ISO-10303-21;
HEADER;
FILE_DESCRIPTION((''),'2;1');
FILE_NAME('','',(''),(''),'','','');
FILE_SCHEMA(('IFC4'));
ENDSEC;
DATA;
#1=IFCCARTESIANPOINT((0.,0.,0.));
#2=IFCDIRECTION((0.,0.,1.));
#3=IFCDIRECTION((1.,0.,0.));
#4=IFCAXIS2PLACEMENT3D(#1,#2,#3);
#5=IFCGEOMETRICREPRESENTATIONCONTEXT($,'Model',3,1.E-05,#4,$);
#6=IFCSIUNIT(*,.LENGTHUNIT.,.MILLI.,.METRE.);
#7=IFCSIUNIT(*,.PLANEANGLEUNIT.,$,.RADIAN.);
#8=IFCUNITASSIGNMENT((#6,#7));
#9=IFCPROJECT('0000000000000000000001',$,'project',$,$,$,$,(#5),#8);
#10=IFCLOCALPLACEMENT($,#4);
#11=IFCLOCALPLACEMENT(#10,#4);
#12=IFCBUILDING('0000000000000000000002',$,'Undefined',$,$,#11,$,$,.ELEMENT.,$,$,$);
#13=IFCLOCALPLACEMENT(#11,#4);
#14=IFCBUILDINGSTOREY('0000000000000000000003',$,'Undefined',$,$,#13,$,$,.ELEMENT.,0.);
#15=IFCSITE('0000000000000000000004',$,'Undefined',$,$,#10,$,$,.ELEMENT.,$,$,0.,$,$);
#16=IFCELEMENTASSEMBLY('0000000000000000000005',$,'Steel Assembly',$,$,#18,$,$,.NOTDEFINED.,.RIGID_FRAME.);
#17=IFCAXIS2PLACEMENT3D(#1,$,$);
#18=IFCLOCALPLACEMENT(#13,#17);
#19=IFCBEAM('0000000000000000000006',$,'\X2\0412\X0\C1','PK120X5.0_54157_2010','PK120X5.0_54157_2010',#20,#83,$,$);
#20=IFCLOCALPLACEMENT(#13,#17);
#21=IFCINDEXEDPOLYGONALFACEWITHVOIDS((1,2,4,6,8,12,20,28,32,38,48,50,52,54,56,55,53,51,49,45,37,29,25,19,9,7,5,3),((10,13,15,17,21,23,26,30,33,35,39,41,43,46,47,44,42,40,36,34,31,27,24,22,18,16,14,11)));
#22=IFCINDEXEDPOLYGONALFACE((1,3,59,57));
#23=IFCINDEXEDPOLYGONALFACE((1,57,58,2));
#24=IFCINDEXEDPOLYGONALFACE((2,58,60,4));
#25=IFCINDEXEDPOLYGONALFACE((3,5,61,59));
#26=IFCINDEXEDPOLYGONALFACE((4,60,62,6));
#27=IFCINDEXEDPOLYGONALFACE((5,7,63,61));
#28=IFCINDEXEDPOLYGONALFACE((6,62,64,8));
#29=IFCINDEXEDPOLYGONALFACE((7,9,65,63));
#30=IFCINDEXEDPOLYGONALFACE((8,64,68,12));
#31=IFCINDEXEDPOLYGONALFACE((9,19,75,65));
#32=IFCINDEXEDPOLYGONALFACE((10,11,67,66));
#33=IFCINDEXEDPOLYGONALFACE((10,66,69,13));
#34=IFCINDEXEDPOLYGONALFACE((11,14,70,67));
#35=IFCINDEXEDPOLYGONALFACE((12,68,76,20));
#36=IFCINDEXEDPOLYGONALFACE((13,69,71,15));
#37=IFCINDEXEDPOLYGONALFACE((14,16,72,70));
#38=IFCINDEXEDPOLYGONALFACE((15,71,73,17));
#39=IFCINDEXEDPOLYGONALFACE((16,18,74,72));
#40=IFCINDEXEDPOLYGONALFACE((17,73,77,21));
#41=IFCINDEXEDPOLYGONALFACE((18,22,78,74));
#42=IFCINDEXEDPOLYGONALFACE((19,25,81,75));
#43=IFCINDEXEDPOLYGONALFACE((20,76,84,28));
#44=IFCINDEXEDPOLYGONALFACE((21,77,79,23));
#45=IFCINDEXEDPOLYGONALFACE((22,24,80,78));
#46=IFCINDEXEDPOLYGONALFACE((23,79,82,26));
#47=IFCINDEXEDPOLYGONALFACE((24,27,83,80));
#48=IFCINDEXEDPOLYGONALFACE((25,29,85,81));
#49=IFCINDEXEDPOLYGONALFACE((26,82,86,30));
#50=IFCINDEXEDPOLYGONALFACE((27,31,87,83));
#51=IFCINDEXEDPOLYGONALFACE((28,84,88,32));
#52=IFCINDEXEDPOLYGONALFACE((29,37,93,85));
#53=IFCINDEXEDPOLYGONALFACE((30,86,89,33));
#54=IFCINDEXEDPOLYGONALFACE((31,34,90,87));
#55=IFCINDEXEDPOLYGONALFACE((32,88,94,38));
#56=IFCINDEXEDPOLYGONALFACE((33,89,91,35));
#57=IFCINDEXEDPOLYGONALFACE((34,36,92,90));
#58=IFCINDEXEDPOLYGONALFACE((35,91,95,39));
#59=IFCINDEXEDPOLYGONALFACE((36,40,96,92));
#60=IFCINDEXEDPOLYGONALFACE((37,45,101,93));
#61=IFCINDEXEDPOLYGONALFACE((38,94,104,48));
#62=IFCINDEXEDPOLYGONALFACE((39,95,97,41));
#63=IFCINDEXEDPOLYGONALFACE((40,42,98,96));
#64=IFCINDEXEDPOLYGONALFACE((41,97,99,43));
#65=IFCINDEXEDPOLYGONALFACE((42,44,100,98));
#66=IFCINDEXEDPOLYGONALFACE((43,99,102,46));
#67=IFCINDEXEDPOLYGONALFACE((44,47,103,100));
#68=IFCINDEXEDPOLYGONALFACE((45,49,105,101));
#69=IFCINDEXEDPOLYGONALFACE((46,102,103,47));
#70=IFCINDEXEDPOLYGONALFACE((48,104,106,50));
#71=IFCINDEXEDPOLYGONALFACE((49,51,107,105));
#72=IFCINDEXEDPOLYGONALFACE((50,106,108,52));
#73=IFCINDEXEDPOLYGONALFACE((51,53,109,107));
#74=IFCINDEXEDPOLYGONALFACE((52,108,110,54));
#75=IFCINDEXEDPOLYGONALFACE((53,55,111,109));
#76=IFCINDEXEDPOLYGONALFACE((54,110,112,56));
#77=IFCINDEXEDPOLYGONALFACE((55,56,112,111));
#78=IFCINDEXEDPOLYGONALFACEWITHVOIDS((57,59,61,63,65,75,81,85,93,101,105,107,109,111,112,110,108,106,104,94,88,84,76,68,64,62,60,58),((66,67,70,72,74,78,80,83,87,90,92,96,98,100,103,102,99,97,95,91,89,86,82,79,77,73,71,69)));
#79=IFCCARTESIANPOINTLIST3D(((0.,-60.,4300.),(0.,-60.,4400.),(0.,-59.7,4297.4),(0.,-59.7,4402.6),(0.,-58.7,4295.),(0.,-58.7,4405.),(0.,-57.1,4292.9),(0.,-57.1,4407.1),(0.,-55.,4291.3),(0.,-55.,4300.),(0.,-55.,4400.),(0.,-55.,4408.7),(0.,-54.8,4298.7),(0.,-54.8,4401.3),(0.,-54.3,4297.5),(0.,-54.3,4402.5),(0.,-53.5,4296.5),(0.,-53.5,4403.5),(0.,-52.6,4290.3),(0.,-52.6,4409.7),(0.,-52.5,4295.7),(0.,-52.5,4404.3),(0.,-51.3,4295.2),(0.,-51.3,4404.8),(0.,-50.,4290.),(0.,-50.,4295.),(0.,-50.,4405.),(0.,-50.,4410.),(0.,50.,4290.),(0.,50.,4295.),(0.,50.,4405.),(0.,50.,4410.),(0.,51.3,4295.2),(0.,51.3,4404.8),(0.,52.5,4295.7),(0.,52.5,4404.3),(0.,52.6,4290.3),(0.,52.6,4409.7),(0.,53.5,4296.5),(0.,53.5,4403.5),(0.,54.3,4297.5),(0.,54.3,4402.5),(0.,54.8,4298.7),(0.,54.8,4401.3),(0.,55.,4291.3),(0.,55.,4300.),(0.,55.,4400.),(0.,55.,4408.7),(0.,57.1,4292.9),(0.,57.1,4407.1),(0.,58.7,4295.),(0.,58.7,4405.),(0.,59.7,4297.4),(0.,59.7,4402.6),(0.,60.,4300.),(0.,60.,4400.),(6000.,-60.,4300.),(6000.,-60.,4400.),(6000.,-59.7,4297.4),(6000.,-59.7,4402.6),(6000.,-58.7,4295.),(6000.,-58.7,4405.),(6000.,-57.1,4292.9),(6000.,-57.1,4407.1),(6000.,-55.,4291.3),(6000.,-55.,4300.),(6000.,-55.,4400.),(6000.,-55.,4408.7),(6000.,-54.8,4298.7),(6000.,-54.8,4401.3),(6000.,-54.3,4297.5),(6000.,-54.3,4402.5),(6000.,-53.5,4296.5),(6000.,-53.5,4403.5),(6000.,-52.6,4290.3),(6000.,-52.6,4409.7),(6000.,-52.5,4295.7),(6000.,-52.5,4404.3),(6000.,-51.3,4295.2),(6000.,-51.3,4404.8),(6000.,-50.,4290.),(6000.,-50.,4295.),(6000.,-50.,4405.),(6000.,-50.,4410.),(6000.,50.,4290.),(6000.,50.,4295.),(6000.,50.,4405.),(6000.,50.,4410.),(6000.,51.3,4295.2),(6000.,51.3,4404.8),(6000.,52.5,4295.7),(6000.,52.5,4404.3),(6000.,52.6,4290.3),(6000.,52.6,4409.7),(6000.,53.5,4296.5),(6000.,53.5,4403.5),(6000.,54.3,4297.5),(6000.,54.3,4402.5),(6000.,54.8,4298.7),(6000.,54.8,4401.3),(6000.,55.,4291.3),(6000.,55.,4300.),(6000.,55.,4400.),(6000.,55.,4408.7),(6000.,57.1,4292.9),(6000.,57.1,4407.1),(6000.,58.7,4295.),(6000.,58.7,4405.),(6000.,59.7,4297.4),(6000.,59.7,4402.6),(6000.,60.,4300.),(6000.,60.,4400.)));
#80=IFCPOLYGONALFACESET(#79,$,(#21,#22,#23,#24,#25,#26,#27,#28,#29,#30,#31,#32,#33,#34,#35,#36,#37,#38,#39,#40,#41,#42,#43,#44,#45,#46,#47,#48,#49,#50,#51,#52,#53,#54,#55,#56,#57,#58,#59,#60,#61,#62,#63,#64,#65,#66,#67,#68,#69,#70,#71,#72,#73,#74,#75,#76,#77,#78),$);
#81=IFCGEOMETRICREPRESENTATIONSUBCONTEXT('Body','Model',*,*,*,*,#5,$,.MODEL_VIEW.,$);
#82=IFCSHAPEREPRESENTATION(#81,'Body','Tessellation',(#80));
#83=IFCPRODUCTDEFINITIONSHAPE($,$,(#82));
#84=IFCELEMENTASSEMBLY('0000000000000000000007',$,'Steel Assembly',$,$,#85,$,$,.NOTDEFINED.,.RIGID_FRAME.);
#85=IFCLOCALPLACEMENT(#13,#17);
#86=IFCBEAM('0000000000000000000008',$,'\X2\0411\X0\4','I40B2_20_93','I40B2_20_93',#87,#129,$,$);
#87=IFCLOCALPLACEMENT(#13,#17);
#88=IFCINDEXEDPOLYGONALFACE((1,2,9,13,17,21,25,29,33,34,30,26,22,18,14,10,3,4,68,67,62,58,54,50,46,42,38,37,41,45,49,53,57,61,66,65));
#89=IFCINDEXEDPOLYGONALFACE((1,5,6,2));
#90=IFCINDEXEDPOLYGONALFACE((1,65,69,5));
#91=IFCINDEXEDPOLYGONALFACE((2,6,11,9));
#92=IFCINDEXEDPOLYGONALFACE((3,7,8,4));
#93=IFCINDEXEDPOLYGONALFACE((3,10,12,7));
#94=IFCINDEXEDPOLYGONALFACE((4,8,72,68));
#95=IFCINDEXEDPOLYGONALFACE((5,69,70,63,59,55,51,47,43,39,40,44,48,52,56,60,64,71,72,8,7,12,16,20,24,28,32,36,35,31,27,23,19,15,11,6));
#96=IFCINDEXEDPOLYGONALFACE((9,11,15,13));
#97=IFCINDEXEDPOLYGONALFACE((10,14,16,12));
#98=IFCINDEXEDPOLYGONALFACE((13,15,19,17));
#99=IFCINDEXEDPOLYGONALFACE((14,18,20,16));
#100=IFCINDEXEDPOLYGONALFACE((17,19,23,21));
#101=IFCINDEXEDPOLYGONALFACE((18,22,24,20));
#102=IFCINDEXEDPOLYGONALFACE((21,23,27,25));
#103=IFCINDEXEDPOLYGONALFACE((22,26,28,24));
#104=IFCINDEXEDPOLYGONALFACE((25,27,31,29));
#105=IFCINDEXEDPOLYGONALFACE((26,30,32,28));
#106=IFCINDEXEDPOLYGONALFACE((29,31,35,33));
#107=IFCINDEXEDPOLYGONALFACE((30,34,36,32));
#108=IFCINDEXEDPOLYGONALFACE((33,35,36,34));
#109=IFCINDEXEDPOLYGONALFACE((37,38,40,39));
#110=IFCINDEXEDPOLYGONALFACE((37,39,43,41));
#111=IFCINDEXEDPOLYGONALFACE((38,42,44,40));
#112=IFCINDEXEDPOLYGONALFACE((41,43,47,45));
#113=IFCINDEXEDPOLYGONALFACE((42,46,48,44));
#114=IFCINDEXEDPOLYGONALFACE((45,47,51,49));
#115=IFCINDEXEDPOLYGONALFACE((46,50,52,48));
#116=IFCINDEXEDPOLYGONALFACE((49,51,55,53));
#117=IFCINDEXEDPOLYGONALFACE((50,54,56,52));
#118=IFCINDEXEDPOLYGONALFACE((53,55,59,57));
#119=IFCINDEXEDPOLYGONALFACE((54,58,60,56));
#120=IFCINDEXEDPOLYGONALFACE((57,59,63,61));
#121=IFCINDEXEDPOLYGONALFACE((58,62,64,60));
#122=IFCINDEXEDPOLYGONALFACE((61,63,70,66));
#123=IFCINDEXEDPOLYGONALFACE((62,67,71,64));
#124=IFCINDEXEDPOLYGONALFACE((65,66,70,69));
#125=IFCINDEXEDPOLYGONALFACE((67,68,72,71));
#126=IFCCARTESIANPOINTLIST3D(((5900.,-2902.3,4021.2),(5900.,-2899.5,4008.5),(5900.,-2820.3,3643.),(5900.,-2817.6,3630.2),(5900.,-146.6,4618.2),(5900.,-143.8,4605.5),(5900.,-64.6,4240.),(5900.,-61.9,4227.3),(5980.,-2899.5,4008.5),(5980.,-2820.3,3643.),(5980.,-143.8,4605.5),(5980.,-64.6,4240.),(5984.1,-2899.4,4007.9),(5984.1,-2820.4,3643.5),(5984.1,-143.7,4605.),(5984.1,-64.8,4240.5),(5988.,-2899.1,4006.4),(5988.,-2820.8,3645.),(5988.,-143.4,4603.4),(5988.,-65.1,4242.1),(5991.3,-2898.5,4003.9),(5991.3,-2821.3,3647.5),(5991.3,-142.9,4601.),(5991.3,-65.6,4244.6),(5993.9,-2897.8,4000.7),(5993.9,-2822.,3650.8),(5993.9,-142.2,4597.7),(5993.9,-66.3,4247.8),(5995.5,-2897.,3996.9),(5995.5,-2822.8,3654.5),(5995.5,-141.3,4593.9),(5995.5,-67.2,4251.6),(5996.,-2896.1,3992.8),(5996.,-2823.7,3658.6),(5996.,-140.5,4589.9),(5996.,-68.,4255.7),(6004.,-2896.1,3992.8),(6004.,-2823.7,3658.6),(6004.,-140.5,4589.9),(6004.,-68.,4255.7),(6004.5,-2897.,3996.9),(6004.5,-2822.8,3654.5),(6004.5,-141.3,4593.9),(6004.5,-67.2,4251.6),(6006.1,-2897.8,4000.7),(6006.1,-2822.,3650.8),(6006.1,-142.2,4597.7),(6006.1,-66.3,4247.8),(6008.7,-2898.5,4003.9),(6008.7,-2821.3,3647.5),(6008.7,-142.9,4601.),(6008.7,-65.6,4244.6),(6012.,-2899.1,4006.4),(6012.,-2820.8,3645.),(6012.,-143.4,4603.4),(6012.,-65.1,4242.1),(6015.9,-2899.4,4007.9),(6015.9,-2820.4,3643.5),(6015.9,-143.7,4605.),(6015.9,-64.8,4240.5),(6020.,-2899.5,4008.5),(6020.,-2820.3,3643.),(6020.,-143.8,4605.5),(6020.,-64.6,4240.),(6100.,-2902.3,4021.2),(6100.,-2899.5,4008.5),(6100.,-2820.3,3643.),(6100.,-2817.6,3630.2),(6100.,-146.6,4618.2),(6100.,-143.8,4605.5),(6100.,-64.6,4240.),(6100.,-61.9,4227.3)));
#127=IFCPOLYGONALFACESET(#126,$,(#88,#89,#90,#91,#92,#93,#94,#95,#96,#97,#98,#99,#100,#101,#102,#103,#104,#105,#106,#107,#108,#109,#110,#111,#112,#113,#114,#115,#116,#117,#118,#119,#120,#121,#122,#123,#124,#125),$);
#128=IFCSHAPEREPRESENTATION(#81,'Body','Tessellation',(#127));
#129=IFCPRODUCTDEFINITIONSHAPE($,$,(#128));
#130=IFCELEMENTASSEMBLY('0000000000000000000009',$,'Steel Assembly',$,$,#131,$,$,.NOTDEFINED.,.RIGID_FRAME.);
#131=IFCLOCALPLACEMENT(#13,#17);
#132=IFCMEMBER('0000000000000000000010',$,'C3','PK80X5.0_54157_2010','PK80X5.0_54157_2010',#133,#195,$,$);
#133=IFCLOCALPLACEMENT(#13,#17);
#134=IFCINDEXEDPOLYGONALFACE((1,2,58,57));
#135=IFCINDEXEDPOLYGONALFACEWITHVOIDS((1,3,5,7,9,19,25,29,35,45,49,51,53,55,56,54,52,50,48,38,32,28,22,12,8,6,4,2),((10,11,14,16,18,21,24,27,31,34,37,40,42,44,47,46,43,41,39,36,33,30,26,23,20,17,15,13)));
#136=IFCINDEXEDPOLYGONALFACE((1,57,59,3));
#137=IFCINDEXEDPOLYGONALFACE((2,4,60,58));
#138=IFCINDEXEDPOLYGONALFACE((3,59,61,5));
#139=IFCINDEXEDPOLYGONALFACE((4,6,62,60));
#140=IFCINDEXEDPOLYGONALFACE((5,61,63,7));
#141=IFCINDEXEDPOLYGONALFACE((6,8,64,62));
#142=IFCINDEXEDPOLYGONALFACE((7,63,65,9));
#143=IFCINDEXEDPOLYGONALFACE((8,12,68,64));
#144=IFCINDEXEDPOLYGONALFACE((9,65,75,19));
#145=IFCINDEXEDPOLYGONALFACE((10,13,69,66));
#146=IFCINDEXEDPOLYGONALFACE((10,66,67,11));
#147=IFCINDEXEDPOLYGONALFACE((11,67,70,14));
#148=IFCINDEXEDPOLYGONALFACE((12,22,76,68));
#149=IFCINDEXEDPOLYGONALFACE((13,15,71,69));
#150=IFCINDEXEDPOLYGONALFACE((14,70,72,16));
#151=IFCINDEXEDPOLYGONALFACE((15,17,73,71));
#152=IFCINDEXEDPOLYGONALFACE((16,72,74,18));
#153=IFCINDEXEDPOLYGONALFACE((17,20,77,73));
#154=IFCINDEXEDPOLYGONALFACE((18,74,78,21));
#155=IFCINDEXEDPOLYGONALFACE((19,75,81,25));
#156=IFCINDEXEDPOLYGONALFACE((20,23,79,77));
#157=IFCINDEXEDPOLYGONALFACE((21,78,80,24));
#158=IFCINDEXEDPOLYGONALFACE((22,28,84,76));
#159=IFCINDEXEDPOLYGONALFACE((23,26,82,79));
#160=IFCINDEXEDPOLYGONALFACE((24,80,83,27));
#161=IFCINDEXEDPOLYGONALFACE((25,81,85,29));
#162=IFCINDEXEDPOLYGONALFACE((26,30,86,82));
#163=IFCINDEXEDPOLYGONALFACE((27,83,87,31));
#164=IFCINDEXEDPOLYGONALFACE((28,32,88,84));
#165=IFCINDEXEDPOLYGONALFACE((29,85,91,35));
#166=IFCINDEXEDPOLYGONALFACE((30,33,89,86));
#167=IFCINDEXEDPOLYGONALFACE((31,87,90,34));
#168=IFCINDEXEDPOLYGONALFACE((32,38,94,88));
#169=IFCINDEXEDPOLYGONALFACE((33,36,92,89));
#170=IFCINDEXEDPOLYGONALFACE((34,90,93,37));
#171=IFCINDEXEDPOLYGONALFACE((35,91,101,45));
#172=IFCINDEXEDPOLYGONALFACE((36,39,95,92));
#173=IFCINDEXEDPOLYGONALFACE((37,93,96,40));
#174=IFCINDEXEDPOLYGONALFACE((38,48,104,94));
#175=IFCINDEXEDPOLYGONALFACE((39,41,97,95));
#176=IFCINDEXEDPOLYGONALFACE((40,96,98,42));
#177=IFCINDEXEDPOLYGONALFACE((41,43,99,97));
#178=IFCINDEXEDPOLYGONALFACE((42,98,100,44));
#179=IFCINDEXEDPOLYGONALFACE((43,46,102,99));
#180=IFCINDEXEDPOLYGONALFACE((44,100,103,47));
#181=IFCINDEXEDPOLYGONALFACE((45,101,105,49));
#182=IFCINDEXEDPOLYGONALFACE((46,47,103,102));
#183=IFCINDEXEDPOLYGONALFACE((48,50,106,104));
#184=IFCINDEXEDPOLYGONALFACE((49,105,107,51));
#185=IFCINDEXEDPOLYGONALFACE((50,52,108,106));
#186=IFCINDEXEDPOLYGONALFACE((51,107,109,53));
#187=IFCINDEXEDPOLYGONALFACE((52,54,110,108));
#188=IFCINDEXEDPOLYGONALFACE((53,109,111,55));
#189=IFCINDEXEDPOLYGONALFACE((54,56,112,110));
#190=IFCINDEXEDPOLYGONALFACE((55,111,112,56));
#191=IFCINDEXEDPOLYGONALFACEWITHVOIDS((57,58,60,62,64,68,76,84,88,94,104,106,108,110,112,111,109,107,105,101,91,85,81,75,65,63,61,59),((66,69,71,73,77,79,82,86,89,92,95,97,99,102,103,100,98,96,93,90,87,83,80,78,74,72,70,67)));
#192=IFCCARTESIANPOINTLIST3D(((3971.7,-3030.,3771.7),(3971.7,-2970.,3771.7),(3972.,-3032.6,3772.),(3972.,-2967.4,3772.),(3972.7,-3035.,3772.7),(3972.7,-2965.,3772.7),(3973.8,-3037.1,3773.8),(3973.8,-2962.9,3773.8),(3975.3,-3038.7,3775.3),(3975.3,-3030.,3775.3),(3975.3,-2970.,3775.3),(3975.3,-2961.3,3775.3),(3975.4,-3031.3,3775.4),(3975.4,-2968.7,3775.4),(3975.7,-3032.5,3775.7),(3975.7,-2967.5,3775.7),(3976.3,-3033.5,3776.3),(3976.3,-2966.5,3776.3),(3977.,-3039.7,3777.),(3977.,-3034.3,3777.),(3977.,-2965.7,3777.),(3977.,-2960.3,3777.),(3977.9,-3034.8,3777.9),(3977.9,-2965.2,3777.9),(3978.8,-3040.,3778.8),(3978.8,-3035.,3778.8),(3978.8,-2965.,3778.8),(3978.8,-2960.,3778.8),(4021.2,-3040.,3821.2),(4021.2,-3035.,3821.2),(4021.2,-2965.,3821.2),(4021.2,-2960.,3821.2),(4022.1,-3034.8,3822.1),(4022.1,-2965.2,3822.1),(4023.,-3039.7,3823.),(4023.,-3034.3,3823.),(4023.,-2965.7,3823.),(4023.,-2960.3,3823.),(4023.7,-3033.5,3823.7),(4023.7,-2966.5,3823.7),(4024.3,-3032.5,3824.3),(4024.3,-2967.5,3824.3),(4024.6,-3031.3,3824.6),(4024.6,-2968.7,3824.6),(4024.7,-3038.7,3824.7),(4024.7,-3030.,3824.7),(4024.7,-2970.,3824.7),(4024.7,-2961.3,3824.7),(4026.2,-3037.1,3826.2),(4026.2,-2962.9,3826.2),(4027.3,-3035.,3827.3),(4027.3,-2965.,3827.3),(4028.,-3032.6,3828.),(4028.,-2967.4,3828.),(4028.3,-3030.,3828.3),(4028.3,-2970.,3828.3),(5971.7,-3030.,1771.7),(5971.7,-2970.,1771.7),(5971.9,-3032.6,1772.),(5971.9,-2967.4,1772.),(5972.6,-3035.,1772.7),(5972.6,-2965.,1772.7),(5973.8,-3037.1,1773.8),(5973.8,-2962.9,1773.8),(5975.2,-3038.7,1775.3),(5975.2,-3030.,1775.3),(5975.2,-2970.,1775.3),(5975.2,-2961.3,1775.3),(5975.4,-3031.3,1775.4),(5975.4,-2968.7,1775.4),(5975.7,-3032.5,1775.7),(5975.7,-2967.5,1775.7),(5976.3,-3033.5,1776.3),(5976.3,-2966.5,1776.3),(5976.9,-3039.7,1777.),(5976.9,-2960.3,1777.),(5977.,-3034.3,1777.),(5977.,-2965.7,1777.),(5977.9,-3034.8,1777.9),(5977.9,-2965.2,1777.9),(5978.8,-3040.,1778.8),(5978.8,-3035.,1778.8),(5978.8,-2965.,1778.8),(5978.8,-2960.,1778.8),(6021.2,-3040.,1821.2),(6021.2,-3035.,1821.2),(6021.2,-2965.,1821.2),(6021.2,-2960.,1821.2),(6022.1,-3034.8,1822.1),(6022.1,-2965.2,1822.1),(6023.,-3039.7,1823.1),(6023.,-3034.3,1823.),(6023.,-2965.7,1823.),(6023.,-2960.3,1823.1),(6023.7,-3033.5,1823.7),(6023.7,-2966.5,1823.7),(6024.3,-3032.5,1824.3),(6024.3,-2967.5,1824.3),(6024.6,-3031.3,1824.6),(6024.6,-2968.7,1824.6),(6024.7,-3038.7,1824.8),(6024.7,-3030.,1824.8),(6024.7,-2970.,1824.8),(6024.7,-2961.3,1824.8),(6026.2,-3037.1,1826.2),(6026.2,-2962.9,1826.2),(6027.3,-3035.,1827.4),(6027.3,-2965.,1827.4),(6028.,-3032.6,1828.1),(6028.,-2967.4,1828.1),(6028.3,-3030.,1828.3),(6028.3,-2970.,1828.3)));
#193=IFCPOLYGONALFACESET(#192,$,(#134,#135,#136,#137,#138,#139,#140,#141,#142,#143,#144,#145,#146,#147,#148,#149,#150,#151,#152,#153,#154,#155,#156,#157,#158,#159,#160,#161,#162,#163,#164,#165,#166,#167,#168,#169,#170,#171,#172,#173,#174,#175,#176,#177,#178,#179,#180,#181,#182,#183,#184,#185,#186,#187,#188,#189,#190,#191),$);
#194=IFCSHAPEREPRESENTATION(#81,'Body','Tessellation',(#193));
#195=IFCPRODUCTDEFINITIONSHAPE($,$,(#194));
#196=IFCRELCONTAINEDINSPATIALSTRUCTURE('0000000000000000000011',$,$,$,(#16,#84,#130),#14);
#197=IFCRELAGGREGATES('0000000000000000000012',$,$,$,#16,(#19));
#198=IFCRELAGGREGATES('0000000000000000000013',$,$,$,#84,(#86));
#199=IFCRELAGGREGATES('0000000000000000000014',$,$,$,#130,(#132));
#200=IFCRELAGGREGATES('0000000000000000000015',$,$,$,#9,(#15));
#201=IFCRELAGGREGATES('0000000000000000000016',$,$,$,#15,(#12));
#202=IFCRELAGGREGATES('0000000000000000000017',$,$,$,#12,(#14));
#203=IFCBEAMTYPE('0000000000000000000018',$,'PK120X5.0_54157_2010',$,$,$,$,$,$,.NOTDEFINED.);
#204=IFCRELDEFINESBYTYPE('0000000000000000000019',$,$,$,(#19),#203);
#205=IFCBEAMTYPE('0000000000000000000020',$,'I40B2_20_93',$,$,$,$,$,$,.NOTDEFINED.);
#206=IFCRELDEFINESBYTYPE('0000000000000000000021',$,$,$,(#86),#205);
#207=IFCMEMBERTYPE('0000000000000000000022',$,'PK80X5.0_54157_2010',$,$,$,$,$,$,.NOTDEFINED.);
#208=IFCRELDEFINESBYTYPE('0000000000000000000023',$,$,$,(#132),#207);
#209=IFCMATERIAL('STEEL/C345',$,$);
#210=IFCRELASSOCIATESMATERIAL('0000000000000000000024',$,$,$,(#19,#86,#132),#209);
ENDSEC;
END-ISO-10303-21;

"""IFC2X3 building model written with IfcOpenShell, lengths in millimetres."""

from ifc_helpers import new_model, si_unit, frame, origin_with_axes, origin_2d_with_axis, place, context, subcontext, project, spatial, hollow_rectangle, i_section, extrude, material, type_object, element, aggregate, save


model = new_model("IFC2X3")

# Units and contexts
model_context = context("Model", 3, precision=1e-05, world=origin_with_axes())
body_context = subcontext(model_context, "Body", "Model", "MODEL_VIEW")
ifc_project = project(units=[si_unit("LENGTHUNIT", "METRE", prefix="MILLI"), si_unit("PLANEANGLEUNIT", "RADIAN")], contexts=[model_context])

# Site, building, storey
site_placement = place(None, origin_with_axes())
site = spatial("IfcSite", under=ifc_project, at=site_placement, Name="Undefined", CompositionType="ELEMENT", RefElevation=0.0)
building_placement = place(site_placement, origin_with_axes())
building = spatial("IfcBuilding", under=site, at=building_placement, Name="Undefined", CompositionType="ELEMENT")
storey_placement = place(building_placement, origin_with_axes())
storey = spatial("IfcBuildingStorey", under=building, at=storey_placement, Name="Undefined", CompositionType="ELEMENT", Elevation=0.0)

# Shared definitions
ifc_material_1 = material(Name="STEEL/C345")

# Element assemblies, beams
assembly_1_placement = place(storey_placement, origin_with_axes())
assembly_1 = element("IfcElementAssembly", 1, at=assembly_1_placement, inside=storey, Name="Steel Assembly", AssemblyPlace="NOTDEFINED", PredefinedType="RIGID_FRAME")
beam_type_1 = type_object("IfcBeamType", Name="PK120X5.0_54157_2010", PredefinedType="NOTDEFINED")
beam_1_placement = place(assembly_1_placement, frame((6000.0, 0.0, 4350.0), z_axis=(0.0, 0.0, 1.0), x_axis=(-1.0, 0.0, 0.0)))
beam_1 = element("IfcBeam", 2, at=beam_1_placement, type_object=beam_type_1, material=ifc_material_1, Name="ВC1", Description="PK120X5.0_54157_2010", ObjectType="PK120X5.0_54157_2010", context=body_context, shape_type="SweptSolid", body=[
    extrude(hollow_rectangle(XDim=120.0, YDim=120.0, WallThickness=5.0, InnerFilletRadius=5.0, OuterFilletRadius=10.0, at=origin_2d_with_axis()), frame((6000.0, 0.0, 0.0), z_axis=(-1.0, 0.0, 0.0), x_axis=(0.0, -1.0, 0.0)), (0.0, 0.0, 1.0), 6000.0),
])
aggregate(assembly_1, [beam_1])
assembly_2_placement = place(storey_placement, origin_with_axes())
assembly_2 = element("IfcElementAssembly", 3, at=assembly_2_placement, inside=storey, Name="Steel Assembly", AssemblyPlace="NOTDEFINED", PredefinedType="RIGID_FRAME")
beam_type_2 = type_object("IfcBeamType", Name="I40B2_20_93", PredefinedType="NOTDEFINED")
beam_2_placement = place(assembly_2_placement, frame((6000.0, -2859.9, 3825.7), z_axis=(0.0, -0.211753, 0.977323), x_axis=(0.0, 0.977323, 0.211753)))
beam_2 = element("IfcBeam", 4, at=beam_2_placement, type_object=beam_type_2, material=ifc_material_1, Name="Б4", Description="I40B2_20_93", ObjectType="I40B2_20_93", context=body_context, shape_type="SweptSolid", body=[
    extrude(i_section(OverallWidth=200.0, OverallDepth=400.0, WebThickness=8.0, FlangeThickness=13.0, FilletRadius=16.0, at=origin_2d_with_axis()), frame((2819.6, 0.0, 0.0), z_axis=(-1.0, 0.0, 0.0), x_axis=(0.0, -1.0, 0.0)), (0.0, 0.0, 1.0), 2819.6),
])
aggregate(assembly_2, [beam_2])

# Element assembly, member
assembly_3_placement = place(storey_placement, origin_with_axes())
assembly_3 = element("IfcElementAssembly", 5, at=assembly_3_placement, inside=storey, Name="Steel Assembly", AssemblyPlace="NOTDEFINED", PredefinedType="RIGID_FRAME")
member_type_1 = type_object("IfcMemberType", Name="PK80X5.0_54157_2010", PredefinedType="NOTDEFINED")
member_1_placement = place(assembly_3_placement, frame((6000.0, -3000.0, 1800.0), z_axis=(0.707107, 0.0, 0.707107), x_axis=(-0.707107, 0.0, 0.707107)))
member_1 = element("IfcMember", 6, at=member_1_placement, type_object=member_type_1, material=ifc_material_1, Name="C3", Description="PK80X5.0_54157_2010", ObjectType="PK80X5.0_54157_2010", context=body_context, shape_type="SweptSolid", body=[
    extrude(hollow_rectangle(XDim=80.0, YDim=80.0, WallThickness=5.0, InnerFilletRadius=5.0, OuterFilletRadius=10.0, at=origin_2d_with_axis()), frame((2828.4, 0.0, 0.0), z_axis=(-1.0, 0.0, 0.0), x_axis=(0.0, -1.0, 0.0)), (0.0, 0.0, 1.0), 2828.4),
])
aggregate(assembly_3, [member_1])

save(model, "model.ifc")
